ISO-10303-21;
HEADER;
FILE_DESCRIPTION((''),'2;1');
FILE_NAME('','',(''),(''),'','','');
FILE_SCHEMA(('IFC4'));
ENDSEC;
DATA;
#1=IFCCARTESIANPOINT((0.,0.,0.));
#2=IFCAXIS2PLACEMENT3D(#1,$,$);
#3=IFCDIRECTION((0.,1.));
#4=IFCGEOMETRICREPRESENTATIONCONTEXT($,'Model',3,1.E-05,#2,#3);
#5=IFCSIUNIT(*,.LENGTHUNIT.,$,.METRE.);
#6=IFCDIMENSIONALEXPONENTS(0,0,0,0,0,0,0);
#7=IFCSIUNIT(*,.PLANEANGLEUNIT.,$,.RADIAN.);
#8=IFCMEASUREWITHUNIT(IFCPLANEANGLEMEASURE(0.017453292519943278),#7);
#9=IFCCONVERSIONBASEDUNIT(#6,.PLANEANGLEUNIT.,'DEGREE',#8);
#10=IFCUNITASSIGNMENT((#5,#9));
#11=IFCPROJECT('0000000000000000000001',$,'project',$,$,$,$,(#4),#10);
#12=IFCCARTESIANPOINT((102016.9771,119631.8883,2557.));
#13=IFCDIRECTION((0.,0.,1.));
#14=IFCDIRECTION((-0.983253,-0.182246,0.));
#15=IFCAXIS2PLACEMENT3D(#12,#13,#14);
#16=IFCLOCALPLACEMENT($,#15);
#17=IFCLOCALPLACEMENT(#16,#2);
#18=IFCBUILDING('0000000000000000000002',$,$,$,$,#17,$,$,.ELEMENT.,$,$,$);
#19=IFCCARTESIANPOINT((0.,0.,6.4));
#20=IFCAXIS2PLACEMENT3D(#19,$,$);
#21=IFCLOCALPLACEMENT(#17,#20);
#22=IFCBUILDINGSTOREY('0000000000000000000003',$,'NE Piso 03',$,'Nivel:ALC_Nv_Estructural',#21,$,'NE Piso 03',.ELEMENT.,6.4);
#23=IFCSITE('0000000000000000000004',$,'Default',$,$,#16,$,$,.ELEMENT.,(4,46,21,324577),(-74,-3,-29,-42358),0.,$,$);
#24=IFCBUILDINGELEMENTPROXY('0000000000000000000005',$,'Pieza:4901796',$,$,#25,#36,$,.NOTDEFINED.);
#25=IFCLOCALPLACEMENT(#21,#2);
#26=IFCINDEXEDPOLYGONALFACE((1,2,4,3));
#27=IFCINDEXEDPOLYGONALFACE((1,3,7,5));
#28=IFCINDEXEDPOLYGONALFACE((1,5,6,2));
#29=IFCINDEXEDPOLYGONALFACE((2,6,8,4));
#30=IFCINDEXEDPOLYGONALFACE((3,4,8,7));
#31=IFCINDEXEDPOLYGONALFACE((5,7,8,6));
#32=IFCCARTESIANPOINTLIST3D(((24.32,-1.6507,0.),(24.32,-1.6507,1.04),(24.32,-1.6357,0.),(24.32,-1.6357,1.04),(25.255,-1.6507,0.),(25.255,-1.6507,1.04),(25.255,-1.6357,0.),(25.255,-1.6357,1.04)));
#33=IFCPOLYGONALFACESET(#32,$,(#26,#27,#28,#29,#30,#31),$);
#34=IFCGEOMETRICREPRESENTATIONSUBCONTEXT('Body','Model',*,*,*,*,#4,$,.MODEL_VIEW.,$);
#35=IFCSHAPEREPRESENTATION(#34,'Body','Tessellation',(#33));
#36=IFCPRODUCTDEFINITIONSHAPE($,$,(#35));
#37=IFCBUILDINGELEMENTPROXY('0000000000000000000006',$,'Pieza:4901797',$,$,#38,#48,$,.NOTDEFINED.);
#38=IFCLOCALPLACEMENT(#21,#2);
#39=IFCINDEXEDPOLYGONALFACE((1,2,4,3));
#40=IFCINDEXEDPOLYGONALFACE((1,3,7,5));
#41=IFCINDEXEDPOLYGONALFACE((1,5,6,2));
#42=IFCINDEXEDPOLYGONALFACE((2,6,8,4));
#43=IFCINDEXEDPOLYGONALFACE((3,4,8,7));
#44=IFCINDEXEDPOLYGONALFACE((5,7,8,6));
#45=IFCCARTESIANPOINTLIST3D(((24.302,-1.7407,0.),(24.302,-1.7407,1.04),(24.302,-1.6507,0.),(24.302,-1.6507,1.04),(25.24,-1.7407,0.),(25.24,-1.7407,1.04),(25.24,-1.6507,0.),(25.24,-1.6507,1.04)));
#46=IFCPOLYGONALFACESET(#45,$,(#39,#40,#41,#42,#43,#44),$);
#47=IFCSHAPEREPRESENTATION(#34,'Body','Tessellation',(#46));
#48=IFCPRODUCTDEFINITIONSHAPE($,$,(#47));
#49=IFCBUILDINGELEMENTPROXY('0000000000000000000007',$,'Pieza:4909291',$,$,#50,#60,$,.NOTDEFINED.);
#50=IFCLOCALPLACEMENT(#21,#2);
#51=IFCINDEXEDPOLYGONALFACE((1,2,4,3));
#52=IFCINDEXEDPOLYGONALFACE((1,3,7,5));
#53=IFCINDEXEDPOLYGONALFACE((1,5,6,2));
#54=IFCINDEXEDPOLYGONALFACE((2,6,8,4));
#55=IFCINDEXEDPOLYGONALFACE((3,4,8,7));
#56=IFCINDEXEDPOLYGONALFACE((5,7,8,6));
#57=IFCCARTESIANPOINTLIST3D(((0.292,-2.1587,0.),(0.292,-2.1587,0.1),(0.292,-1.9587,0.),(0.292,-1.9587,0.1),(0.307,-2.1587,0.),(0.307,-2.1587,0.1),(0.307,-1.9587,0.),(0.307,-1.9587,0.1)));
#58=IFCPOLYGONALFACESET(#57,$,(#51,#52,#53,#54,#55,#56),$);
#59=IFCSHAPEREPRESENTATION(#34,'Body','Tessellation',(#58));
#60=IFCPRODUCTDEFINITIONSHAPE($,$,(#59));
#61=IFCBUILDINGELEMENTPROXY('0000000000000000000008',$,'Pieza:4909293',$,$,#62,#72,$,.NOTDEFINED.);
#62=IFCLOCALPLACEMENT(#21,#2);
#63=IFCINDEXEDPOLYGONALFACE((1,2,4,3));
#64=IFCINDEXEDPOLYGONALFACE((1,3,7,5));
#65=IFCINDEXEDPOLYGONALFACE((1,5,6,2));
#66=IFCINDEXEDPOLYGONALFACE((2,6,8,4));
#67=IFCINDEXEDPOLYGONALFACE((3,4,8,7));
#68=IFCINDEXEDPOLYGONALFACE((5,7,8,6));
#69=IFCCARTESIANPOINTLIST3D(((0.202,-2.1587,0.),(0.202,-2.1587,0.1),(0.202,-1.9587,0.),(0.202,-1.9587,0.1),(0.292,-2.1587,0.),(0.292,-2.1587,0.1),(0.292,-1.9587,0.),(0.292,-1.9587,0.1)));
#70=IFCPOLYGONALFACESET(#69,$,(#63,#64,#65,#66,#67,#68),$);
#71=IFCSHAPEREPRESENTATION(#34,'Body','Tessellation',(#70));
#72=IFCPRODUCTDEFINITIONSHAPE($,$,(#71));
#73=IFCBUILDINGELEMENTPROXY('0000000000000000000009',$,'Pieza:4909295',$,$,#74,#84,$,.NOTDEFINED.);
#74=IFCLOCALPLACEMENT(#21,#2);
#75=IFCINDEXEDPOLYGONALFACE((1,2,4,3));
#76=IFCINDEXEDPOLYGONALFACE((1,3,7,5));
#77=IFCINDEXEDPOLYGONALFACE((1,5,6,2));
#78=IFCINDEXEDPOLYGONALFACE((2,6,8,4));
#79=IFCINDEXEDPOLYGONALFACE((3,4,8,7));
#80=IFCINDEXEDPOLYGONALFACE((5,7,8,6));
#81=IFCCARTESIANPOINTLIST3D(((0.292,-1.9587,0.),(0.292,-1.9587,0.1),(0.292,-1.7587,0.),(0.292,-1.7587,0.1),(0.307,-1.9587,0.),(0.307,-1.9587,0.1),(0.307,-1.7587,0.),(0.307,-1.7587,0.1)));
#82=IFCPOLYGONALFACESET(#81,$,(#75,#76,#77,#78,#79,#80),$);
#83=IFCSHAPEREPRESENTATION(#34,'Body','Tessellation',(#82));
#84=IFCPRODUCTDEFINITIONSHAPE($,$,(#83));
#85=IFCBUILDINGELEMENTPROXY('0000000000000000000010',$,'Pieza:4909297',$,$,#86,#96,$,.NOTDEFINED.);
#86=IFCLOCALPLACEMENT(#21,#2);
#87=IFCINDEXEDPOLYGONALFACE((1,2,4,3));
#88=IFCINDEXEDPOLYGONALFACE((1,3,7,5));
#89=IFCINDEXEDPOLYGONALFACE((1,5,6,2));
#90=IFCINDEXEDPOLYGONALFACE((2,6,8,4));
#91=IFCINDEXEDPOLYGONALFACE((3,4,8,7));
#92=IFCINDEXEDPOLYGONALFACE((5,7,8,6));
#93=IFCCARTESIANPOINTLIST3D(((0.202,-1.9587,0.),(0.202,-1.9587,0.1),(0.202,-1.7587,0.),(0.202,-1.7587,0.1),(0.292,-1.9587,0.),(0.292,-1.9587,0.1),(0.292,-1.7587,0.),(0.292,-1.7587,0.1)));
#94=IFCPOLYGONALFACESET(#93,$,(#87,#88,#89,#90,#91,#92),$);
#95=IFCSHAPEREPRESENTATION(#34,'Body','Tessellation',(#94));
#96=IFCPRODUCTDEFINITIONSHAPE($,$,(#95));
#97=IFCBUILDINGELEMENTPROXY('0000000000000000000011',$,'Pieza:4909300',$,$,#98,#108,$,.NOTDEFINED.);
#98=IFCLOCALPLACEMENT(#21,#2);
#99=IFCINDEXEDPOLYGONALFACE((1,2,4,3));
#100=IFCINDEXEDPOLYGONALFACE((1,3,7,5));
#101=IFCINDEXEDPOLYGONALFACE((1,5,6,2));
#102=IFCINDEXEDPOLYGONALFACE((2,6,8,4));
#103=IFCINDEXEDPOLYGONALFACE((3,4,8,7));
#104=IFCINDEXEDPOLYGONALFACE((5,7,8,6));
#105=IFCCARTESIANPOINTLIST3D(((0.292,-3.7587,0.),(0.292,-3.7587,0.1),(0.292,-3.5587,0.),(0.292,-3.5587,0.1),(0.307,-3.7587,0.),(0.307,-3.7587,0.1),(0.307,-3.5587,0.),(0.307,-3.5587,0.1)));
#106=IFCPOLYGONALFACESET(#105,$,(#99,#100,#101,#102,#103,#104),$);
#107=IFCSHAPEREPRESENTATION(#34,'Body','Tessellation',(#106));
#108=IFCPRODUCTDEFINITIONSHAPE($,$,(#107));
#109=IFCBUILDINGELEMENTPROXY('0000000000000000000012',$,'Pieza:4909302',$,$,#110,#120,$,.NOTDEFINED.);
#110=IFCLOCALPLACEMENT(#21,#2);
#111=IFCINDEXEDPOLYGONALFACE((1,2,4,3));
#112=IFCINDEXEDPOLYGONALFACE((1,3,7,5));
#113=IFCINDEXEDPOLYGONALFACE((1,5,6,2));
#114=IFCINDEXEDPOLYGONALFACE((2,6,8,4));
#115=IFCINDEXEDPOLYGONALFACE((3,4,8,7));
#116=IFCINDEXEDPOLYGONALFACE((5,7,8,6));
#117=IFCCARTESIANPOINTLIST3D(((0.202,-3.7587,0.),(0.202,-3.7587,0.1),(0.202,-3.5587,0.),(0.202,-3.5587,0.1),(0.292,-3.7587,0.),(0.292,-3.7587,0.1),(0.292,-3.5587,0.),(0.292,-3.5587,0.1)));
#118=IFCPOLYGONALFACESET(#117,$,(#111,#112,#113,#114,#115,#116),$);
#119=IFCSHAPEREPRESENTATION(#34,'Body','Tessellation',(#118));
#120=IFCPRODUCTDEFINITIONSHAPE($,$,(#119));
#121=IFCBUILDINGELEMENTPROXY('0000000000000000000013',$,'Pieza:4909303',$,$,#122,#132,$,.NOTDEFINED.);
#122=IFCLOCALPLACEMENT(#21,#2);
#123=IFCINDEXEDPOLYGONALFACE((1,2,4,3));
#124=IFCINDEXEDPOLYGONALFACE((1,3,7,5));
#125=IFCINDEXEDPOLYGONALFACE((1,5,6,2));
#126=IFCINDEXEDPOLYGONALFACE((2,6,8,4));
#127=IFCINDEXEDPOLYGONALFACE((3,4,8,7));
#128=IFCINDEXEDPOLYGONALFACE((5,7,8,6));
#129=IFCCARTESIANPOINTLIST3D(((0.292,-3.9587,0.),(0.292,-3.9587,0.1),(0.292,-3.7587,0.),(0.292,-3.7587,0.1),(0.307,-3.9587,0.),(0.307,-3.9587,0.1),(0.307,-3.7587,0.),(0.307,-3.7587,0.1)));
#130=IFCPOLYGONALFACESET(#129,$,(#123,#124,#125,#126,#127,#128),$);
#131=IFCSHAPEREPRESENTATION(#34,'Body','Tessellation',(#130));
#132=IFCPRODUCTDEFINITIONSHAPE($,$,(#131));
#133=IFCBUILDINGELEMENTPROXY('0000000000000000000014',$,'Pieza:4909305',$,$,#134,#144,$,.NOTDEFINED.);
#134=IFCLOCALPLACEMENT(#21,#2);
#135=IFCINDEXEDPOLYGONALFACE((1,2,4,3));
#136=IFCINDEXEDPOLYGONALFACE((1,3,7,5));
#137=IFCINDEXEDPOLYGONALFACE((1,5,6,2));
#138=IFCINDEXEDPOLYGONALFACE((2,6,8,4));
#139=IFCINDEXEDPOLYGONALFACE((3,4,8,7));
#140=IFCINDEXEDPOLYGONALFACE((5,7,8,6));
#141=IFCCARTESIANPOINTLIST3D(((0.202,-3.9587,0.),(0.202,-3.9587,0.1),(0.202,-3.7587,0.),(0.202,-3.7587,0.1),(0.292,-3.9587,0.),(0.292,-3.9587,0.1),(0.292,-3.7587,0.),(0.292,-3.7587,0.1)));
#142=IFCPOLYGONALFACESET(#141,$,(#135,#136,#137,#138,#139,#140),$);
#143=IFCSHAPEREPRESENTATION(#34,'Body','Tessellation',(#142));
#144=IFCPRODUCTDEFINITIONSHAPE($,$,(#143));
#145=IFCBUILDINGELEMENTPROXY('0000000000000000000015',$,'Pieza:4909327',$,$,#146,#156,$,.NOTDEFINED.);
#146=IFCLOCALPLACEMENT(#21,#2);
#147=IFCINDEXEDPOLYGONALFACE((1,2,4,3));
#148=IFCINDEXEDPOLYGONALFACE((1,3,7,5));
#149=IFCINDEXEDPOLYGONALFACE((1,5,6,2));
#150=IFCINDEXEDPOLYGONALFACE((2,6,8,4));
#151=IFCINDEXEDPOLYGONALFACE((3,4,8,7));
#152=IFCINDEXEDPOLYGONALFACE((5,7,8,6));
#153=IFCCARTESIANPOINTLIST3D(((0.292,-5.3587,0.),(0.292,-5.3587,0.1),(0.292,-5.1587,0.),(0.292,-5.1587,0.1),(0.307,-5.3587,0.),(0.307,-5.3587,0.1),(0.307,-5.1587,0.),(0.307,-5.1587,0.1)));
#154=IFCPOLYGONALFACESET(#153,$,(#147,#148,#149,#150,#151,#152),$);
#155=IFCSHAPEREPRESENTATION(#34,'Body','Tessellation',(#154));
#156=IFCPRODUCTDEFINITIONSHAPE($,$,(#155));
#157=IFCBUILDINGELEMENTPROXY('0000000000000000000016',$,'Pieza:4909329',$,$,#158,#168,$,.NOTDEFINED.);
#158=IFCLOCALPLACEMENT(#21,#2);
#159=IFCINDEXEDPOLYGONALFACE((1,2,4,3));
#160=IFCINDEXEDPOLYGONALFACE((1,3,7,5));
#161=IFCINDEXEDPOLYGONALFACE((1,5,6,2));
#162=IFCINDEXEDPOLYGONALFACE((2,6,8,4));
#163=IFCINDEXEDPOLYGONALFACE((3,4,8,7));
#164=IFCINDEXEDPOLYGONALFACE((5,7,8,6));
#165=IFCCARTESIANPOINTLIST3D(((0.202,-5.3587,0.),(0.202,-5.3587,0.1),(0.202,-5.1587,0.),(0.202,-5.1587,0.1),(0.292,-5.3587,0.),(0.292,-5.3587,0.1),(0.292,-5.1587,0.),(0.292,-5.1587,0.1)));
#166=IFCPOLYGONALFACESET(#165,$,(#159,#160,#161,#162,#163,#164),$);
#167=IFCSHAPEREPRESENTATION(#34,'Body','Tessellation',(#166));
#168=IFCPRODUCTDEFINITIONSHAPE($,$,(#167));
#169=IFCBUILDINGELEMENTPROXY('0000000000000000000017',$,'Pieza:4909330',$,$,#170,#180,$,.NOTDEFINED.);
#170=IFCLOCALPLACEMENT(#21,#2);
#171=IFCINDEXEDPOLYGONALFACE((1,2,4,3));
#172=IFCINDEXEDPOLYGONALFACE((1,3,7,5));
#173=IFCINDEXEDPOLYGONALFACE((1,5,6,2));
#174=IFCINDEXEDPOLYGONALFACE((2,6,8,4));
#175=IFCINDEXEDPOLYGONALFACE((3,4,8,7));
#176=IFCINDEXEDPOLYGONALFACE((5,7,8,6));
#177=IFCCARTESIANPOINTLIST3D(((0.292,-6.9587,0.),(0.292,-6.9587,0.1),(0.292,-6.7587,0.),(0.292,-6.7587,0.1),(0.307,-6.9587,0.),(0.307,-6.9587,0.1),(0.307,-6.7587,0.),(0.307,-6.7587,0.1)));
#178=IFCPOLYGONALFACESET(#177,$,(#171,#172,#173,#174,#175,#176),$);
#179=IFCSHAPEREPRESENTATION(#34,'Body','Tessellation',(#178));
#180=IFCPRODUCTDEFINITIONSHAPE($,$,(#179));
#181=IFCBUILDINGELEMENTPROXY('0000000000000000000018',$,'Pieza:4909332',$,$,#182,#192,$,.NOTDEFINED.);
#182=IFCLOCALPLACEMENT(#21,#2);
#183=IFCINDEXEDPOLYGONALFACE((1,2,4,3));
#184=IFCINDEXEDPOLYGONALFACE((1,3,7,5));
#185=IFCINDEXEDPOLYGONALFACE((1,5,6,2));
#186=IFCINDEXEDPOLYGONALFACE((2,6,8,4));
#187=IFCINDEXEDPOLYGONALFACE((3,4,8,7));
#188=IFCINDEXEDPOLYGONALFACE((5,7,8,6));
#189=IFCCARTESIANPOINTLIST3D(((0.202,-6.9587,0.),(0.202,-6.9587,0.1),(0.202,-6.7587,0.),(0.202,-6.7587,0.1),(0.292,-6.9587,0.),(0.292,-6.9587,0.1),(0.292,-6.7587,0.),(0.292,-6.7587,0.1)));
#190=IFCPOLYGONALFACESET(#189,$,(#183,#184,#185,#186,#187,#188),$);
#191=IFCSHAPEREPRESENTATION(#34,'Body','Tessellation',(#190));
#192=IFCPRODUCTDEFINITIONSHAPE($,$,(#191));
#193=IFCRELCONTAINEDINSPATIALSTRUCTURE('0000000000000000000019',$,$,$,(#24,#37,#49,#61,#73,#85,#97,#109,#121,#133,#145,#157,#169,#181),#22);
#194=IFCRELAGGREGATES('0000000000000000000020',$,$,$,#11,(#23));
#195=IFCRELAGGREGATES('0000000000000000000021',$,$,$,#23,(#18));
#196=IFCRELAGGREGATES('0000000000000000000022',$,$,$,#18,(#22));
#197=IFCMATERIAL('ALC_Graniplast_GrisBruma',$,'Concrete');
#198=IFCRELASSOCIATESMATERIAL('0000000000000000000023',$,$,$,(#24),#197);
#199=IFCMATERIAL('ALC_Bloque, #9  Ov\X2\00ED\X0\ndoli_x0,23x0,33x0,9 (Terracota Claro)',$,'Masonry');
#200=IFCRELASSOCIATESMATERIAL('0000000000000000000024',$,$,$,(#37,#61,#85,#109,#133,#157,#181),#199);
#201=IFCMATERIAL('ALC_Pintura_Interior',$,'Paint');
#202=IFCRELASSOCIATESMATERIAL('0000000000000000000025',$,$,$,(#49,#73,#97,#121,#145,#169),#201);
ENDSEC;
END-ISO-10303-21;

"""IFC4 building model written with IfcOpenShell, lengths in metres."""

from ifc_helpers import new_model, entity, si_unit, converted_unit, direction, frame, frame_2d, origin, place, context, subcontext, project, spatial, rectangle, extrude, material, element, save


model = new_model("IFC4")

# Units and contexts
model_context = context("Model", 3, precision=1e-05, world=origin(), true_north=direction((0.0, 1.0)))
body_context = subcontext(model_context, "Body", "Model", "MODEL_VIEW")
ifc_project = project(units=[si_unit("LENGTHUNIT", "METRE"), converted_unit("PLANEANGLEUNIT", "DEGREE", entity("IfcPlaneAngleMeasure", 0.017453292519943278), si_unit("PLANEANGLEUNIT", "RADIAN"), dimensions=[0, 0, 0, 0, 0, 0, 0])], contexts=[model_context])

# Site, building, storey
site_placement = place(None, frame((102016.9771, 119631.8883, 2557.0), z_axis=(0.0, 0.0, 1.0), x_axis=(-0.983253, -0.182246, 0.0)))
site = spatial("IfcSite", under=ifc_project, at=site_placement, Name="Default", CompositionType="ELEMENT", RefLatitude=(4, 46, 21, 324577), RefLongitude=(-74, -3, -29, -42358), RefElevation=0.0)
building_placement = place(site_placement, origin())
building = spatial("IfcBuilding", under=site, at=building_placement, CompositionType="ELEMENT")
storey_placement = place(building_placement, frame((0.0, 0.0, 6.4)))
storey = spatial("IfcBuildingStorey", under=building, at=storey_placement, Name="NE Piso 03", ObjectType="Nivel:ALC_Nv_Estructural", LongName="NE Piso 03", CompositionType="ELEMENT", Elevation=6.4)

# Shared definitions
ifc_material_1 = material(Name="ALC_Pintura_Interior", Category="Paint")
ifc_material_2 = material(Name="ALC_Bloque, #9  Ovíndoli_x0,23x0,33x0,9 (Terracota Claro)", Category="Masonry")
ifc_material_3 = material(Name="ALC_Graniplast_GrisBruma", Category="Concrete")

# Building element proxies
proxy_1_placement = place(storey_placement, origin())
element("IfcBuildingElementProxy", 1, at=proxy_1_placement, inside=storey, material=ifc_material_3, Name="Pieza:4901796", PredefinedType="NOTDEFINED", context=body_context, shape_type="SweptSolid", body=[
    extrude(rectangle(XDim=1.04, YDim=0.015, at=frame_2d((0.0, 0.0), x_axis=(1.0, 0.0))), frame((24.32, -1.6432, 0.52), z_axis=(1.0, 0.0, 0.0), x_axis=(0.0, 0.0, -1.0)), (0.0, 0.0, 1.0), 0.935),
])
proxy_2_placement = place(storey_placement, origin())
element("IfcBuildingElementProxy", 2, at=proxy_2_placement, inside=storey, material=ifc_material_2, Name="Pieza:4901797", PredefinedType="NOTDEFINED", context=body_context, shape_type="SweptSolid", body=[
    extrude(rectangle(XDim=1.04, YDim=0.09, at=frame_2d((0.0, 0.0), x_axis=(1.0, 0.0))), frame((24.302, -1.6957, 0.52), z_axis=(1.0, 0.0, 0.0), x_axis=(0.0, 0.0, -1.0)), (0.0, 0.0, 1.0), 0.938),
])
proxy_3_placement = place(storey_placement, origin())
element("IfcBuildingElementProxy", 3, at=proxy_3_placement, inside=storey, material=ifc_material_1, Name="Pieza:4909291", PredefinedType="NOTDEFINED", context=body_context, shape_type="SweptSolid", body=[
    extrude(rectangle(XDim=0.1, YDim=0.2, at=frame_2d((0.0, 0.0), x_axis=(1.0, 0.0))), frame((0.292, -2.0587, 0.05), z_axis=(1.0, 0.0, 0.0), x_axis=(0.0, 0.0, -1.0)), (0.0, 0.0, 1.0), 0.015),
])
proxy_4_placement = place(storey_placement, origin())
element("IfcBuildingElementProxy", 4, at=proxy_4_placement, inside=storey, material=ifc_material_2, Name="Pieza:4909293", PredefinedType="NOTDEFINED", context=body_context, shape_type="SweptSolid", body=[
    extrude(rectangle(XDim=0.1, YDim=0.2, at=frame_2d((0.0, 0.0), x_axis=(1.0, 0.0))), frame((0.202, -2.0587, 0.05), z_axis=(1.0, 0.0, 0.0), x_axis=(0.0, 0.0, -1.0)), (0.0, 0.0, 1.0), 0.09),
])
proxy_5_placement = place(storey_placement, origin())
element("IfcBuildingElementProxy", 5, at=proxy_5_placement, inside=storey, material=ifc_material_1, Name="Pieza:4909295", PredefinedType="NOTDEFINED", context=body_context, shape_type="SweptSolid", body=[
    extrude(rectangle(XDim=0.1, YDim=0.2, at=frame_2d((0.0, 0.0), x_axis=(1.0, 0.0))), frame((0.292, -1.8587, 0.05), z_axis=(1.0, 0.0, 0.0), x_axis=(0.0, 0.0, -1.0)), (0.0, 0.0, 1.0), 0.015),
])
proxy_6_placement = place(storey_placement, origin())
element("IfcBuildingElementProxy", 6, at=proxy_6_placement, inside=storey, material=ifc_material_2, Name="Pieza:4909297", PredefinedType="NOTDEFINED", context=body_context, shape_type="SweptSolid", body=[
    extrude(rectangle(XDim=0.1, YDim=0.2, at=frame_2d((0.0, 0.0), x_axis=(1.0, 0.0))), frame((0.202, -1.8587, 0.05), z_axis=(1.0, 0.0, 0.0), x_axis=(0.0, 0.0, -1.0)), (0.0, 0.0, 1.0), 0.09),
])
proxy_7_placement = place(storey_placement, origin())
element("IfcBuildingElementProxy", 7, at=proxy_7_placement, inside=storey, material=ifc_material_1, Name="Pieza:4909300", PredefinedType="NOTDEFINED", context=body_context, shape_type="SweptSolid", body=[
    extrude(rectangle(XDim=0.1, YDim=0.2, at=frame_2d((0.0, 0.0), x_axis=(1.0, 0.0))), frame((0.292, -3.6587, 0.05), z_axis=(1.0, 0.0, 0.0), x_axis=(0.0, 0.0, -1.0)), (0.0, 0.0, 1.0), 0.015),
])
proxy_8_placement = place(storey_placement, origin())
element("IfcBuildingElementProxy", 8, at=proxy_8_placement, inside=storey, material=ifc_material_2, Name="Pieza:4909302", PredefinedType="NOTDEFINED", context=body_context, shape_type="SweptSolid", body=[
    extrude(rectangle(XDim=0.1, YDim=0.2, at=frame_2d((0.0, 0.0), x_axis=(1.0, 0.0))), frame((0.202, -3.6587, 0.05), z_axis=(1.0, 0.0, 0.0), x_axis=(0.0, 0.0, -1.0)), (0.0, 0.0, 1.0), 0.09),
])
proxy_9_placement = place(storey_placement, origin())
element("IfcBuildingElementProxy", 9, at=proxy_9_placement, inside=storey, material=ifc_material_1, Name="Pieza:4909303", PredefinedType="NOTDEFINED", context=body_context, shape_type="SweptSolid", body=[
    extrude(rectangle(XDim=0.1, YDim=0.2, at=frame_2d((0.0, 0.0), x_axis=(1.0, 0.0))), frame((0.292, -3.8587, 0.05), z_axis=(1.0, 0.0, 0.0), x_axis=(0.0, 0.0, -1.0)), (0.0, 0.0, 1.0), 0.015),
])
proxy_10_placement = place(storey_placement, origin())
element("IfcBuildingElementProxy", 10, at=proxy_10_placement, inside=storey, material=ifc_material_2, Name="Pieza:4909305", PredefinedType="NOTDEFINED", context=body_context, shape_type="SweptSolid", body=[
    extrude(rectangle(XDim=0.1, YDim=0.2, at=frame_2d((0.0, 0.0), x_axis=(1.0, 0.0))), frame((0.202, -3.8587, 0.05), z_axis=(1.0, 0.0, 0.0), x_axis=(0.0, 0.0, -1.0)), (0.0, 0.0, 1.0), 0.09),
])
proxy_11_placement = place(storey_placement, origin())
element("IfcBuildingElementProxy", 11, at=proxy_11_placement, inside=storey, material=ifc_material_1, Name="Pieza:4909327", PredefinedType="NOTDEFINED", context=body_context, shape_type="SweptSolid", body=[
    extrude(rectangle(XDim=0.1, YDim=0.2, at=frame_2d((0.0, 0.0), x_axis=(1.0, 0.0))), frame((0.292, -5.2587, 0.05), z_axis=(1.0, 0.0, 0.0), x_axis=(0.0, 0.0, -1.0)), (0.0, 0.0, 1.0), 0.015),
])
proxy_12_placement = place(storey_placement, origin())
element("IfcBuildingElementProxy", 12, at=proxy_12_placement, inside=storey, material=ifc_material_2, Name="Pieza:4909329", PredefinedType="NOTDEFINED", context=body_context, shape_type="SweptSolid", body=[
    extrude(rectangle(XDim=0.1, YDim=0.2, at=frame_2d((0.0, 0.0), x_axis=(1.0, 0.0))), frame((0.202, -5.2587, 0.05), z_axis=(1.0, 0.0, 0.0), x_axis=(0.0, 0.0, -1.0)), (0.0, 0.0, 1.0), 0.09),
])
proxy_13_placement = place(storey_placement, origin())
element("IfcBuildingElementProxy", 13, at=proxy_13_placement, inside=storey, material=ifc_material_1, Name="Pieza:4909330", PredefinedType="NOTDEFINED", context=body_context, shape_type="SweptSolid", body=[
    extrude(rectangle(XDim=0.1, YDim=0.2, at=frame_2d((0.0, 0.0), x_axis=(1.0, 0.0))), frame((0.292, -6.8587, 0.05), z_axis=(1.0, 0.0, 0.0), x_axis=(0.0, 0.0, -1.0)), (0.0, 0.0, 1.0), 0.015),
])
proxy_14_placement = place(storey_placement, origin())
element("IfcBuildingElementProxy", 14, at=proxy_14_placement, inside=storey, material=ifc_material_2, Name="Pieza:4909332", PredefinedType="NOTDEFINED", context=body_context, shape_type="SweptSolid", body=[
    extrude(rectangle(XDim=0.1, YDim=0.2, at=frame_2d((0.0, 0.0), x_axis=(1.0, 0.0))), frame((0.202, -6.8587, 0.05), z_axis=(1.0, 0.0, 0.0), x_axis=(0.0, 0.0, -1.0)), (0.0, 0.0, 1.0), 0.09),
])

save(model, "model.ifc")
